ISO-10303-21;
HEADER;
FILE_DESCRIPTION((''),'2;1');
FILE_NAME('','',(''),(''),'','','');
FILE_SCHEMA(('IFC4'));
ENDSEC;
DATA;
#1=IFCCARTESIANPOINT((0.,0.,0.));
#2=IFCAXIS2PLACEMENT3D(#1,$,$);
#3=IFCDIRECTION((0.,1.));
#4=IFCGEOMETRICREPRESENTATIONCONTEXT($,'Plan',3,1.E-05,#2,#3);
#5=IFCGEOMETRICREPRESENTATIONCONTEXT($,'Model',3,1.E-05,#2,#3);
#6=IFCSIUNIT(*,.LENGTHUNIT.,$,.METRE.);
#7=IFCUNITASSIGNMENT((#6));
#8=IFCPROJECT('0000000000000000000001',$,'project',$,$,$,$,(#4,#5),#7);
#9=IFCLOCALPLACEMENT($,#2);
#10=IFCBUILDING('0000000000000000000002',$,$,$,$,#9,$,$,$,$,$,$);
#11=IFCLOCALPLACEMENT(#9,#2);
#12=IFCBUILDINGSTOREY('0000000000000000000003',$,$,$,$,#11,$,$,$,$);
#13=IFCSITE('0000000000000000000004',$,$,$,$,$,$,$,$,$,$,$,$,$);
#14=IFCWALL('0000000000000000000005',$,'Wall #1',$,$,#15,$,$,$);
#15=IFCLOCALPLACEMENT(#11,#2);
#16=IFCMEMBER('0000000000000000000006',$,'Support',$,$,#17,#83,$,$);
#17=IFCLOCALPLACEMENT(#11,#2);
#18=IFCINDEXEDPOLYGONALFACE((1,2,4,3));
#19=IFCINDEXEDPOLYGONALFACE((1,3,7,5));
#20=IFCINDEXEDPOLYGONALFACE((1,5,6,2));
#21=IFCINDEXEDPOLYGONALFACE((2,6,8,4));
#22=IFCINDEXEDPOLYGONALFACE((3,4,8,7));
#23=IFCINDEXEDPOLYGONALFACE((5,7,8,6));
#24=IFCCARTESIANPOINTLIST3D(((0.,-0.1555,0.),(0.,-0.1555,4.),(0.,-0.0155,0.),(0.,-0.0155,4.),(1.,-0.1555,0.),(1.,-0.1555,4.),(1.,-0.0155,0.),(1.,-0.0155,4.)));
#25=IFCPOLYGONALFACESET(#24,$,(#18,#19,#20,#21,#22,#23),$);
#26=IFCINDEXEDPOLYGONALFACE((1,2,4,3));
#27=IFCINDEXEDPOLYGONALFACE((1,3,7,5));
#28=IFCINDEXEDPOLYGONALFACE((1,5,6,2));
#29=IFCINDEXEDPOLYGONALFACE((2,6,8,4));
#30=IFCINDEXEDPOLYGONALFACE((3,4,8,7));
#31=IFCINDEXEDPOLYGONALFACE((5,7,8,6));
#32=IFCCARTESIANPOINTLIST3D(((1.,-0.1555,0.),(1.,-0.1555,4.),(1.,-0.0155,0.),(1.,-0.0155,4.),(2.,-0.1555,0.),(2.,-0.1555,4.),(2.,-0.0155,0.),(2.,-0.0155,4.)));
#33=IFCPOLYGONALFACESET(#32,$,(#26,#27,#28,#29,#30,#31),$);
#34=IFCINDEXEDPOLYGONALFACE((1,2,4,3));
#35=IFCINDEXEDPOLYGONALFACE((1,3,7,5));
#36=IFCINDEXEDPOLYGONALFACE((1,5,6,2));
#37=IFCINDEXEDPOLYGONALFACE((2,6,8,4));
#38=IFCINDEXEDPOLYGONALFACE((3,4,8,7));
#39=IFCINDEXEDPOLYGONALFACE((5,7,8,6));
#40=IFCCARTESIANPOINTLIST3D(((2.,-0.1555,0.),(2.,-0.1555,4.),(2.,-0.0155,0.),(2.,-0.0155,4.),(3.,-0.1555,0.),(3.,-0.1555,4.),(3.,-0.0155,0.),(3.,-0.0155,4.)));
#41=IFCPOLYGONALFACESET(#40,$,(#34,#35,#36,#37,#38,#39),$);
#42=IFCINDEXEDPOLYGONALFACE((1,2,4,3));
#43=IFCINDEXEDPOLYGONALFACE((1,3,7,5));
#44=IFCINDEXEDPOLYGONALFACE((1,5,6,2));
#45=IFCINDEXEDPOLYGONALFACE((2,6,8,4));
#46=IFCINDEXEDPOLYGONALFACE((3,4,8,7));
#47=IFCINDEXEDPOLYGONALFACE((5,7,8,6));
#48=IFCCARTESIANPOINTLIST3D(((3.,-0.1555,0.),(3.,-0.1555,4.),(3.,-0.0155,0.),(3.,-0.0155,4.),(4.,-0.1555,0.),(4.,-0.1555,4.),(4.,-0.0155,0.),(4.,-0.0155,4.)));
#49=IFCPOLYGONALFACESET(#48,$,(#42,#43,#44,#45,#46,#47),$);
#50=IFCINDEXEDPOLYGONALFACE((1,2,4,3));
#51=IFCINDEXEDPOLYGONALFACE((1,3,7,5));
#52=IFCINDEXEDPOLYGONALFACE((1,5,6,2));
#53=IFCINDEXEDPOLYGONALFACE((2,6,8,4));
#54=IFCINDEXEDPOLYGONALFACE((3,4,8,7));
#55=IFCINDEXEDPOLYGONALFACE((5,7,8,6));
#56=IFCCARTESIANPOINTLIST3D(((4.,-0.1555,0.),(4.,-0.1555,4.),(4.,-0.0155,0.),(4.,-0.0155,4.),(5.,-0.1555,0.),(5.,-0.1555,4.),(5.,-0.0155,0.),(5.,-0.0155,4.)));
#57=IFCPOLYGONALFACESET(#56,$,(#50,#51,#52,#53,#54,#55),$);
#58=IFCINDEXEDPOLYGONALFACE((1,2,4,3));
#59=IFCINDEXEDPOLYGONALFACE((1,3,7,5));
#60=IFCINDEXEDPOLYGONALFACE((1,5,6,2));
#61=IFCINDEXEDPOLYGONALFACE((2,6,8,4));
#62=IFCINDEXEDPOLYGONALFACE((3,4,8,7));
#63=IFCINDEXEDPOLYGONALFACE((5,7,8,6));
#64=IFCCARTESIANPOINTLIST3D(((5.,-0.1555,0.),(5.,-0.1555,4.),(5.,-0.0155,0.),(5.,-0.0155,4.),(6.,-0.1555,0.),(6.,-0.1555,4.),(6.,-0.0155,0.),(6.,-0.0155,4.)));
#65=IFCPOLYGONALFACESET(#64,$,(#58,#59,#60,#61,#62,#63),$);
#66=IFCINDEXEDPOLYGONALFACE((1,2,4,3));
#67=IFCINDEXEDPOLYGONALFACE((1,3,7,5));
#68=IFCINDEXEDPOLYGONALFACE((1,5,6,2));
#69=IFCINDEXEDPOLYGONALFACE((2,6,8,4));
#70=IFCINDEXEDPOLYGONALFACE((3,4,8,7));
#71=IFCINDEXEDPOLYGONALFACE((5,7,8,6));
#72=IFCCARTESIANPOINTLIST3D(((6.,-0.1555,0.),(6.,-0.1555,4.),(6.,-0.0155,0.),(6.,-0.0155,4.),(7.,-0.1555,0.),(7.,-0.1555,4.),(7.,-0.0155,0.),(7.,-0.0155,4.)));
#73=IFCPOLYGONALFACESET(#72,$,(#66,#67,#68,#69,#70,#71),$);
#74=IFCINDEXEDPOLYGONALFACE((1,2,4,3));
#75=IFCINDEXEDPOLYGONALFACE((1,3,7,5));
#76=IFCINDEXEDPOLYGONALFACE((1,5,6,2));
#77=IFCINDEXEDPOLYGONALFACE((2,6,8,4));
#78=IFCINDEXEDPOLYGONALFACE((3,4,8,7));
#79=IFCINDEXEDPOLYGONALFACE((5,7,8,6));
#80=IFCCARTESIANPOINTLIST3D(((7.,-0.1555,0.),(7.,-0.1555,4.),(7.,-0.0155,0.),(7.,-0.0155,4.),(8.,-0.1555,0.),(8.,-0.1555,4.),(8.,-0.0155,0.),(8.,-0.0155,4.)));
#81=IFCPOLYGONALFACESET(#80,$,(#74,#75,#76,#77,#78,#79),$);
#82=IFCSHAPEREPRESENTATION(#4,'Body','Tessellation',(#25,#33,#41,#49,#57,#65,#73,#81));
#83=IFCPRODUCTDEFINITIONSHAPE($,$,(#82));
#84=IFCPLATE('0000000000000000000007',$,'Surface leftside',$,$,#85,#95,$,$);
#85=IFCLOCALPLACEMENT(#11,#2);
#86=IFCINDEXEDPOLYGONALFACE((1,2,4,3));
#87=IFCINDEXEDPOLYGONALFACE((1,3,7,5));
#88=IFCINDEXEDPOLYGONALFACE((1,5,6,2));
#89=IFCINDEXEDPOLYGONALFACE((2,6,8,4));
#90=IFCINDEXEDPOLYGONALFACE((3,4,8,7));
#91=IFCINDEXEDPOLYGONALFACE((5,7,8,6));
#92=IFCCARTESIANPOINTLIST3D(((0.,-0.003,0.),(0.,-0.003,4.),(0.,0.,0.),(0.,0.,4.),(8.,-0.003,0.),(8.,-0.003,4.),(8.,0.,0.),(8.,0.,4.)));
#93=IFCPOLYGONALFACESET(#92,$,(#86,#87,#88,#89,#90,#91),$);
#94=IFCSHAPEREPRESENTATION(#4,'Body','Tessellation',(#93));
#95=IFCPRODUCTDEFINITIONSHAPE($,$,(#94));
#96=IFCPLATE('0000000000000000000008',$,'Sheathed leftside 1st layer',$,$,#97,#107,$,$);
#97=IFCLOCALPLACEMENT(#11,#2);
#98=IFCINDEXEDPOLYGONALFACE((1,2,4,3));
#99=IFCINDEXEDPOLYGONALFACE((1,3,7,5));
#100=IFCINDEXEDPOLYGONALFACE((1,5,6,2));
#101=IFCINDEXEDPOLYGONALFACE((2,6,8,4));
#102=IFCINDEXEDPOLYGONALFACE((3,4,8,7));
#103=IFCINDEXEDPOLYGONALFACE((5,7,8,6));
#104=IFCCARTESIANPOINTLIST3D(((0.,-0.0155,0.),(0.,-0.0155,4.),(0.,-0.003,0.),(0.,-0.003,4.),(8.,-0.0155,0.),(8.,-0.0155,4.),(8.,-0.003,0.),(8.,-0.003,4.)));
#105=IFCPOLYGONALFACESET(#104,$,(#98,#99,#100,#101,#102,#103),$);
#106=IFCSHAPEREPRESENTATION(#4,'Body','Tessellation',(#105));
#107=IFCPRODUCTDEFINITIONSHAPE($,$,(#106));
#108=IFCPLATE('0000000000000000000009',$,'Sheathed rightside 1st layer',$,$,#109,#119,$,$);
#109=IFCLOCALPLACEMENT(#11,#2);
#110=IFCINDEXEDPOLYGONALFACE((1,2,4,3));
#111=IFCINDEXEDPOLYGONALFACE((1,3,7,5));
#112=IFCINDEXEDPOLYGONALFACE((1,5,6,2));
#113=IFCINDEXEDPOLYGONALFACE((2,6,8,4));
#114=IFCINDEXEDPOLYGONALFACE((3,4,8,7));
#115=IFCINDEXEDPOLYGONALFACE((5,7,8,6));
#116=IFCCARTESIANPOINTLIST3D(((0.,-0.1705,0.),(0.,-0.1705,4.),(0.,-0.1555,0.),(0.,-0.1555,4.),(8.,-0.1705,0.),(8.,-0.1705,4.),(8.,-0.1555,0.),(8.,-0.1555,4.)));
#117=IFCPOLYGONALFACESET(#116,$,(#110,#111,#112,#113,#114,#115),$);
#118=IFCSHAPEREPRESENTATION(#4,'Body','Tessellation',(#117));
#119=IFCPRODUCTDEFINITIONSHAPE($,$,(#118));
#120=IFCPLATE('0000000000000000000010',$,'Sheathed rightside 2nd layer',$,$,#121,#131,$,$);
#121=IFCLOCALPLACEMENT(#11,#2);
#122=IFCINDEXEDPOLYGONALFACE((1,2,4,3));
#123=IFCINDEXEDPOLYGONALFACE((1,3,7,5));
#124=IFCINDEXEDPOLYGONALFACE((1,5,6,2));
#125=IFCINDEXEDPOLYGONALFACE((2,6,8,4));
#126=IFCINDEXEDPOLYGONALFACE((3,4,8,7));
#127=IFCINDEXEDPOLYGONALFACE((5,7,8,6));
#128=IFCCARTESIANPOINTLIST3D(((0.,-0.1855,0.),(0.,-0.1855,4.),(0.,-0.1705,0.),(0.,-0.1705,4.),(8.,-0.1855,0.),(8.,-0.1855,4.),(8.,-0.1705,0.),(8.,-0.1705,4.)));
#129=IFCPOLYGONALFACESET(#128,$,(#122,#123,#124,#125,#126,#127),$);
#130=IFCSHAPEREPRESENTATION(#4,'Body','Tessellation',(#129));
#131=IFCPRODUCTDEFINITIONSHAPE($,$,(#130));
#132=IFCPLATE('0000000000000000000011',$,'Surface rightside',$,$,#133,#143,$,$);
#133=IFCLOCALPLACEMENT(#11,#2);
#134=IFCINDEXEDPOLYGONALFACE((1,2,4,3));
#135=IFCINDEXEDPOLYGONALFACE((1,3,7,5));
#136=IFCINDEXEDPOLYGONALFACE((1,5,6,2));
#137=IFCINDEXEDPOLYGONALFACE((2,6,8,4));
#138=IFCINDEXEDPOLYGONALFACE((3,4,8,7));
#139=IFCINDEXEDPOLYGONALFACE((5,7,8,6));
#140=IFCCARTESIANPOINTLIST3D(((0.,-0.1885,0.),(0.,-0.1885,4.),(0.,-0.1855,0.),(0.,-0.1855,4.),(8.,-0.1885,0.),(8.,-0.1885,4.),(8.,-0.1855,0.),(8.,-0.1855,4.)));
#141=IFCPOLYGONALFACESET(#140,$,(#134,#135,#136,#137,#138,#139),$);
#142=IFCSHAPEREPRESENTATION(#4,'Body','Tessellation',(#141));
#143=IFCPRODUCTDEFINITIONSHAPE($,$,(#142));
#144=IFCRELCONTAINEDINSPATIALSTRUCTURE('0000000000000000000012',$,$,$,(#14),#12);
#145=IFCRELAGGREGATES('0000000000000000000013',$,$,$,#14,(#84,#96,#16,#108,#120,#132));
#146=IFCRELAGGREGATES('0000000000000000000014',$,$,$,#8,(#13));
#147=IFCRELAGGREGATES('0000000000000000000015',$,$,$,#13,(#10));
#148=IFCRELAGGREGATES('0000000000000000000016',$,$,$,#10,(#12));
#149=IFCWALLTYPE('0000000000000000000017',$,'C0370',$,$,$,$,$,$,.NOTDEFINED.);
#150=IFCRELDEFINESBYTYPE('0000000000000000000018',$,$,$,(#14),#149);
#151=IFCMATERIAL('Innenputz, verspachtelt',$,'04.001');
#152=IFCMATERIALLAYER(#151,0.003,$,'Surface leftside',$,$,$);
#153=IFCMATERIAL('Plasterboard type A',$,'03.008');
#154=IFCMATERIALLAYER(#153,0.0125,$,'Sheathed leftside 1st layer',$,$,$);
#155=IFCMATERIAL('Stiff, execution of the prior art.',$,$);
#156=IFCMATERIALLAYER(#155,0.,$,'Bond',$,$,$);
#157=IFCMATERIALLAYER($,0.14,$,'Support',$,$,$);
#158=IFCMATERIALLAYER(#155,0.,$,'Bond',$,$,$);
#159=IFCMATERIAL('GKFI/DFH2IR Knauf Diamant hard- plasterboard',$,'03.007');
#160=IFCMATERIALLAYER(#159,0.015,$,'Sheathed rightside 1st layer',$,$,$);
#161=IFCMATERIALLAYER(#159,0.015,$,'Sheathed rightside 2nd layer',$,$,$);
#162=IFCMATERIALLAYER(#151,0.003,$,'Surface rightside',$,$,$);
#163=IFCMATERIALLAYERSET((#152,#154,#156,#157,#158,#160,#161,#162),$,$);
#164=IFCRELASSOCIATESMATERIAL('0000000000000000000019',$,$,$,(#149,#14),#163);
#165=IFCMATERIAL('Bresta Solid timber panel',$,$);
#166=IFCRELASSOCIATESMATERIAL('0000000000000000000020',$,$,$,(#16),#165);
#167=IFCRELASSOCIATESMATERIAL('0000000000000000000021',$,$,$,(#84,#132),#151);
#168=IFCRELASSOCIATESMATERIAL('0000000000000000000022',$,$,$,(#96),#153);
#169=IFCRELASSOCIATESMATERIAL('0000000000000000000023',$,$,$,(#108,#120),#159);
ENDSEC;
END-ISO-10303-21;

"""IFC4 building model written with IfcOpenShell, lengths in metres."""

from ifc_helpers import new_model, si_unit, direction, frame, frame_2d, origin, origin_with_axes, place, context, project, spatial, rectangle, extrude, material, layer, layer_set, type_object, element, aggregate, save


model = new_model("IFC4")

# Units and contexts
plan_context = context("Plan", 3, precision=1e-05, world=origin(), true_north=direction((0.0, 1.0)))
model_context = context("Model", 3, precision=1e-05, world=origin(), true_north=direction((0.0, 1.0)))
ifc_project = project(units=[si_unit("LENGTHUNIT", "METRE")], contexts=[plan_context, model_context])

# Site, building, storey
site = spatial("IfcSite", under=ifc_project)
building_placement = place(None, origin())
building = spatial("IfcBuilding", under=site, at=building_placement)
storey_placement = place(building_placement, origin())
storey = spatial("IfcBuildingStorey", under=building, at=storey_placement)

# Wall, member, plates
ifc_material_1 = material(Name="Innenputz, verspachtelt", Category="04.001")
ifc_layer_1 = layer(ifc_material_1, 0.003, Name="Surface leftside")
ifc_material_2 = material(Name="Plasterboard type A", Category="03.008")
ifc_layer_2 = layer(ifc_material_2, 0.0125, Name="Sheathed leftside 1st layer")
ifc_material_3 = material(Name="Stiff, execution of the prior art.")
ifc_layer_3 = layer(ifc_material_3, 0.0, Name="Bond")
ifc_layer_4 = layer(None, 0.14, Name="Support")
ifc_layer_5 = layer(ifc_material_3, 0.0, Name="Bond")
ifc_material_4 = material(Name="GKFI/DFH2IR Knauf Diamant hard- plasterboard", Category="03.007")
ifc_layer_6 = layer(ifc_material_4, 0.015, Name="Sheathed rightside 1st layer")
ifc_layer_7 = layer(ifc_material_4, 0.015, Name="Sheathed rightside 2nd layer")
ifc_layer_8 = layer(ifc_material_1, 0.003, Name="Surface rightside")
ifc_layer_set = layer_set([ifc_layer_1, ifc_layer_2, ifc_layer_3, ifc_layer_4, ifc_layer_5, ifc_layer_6, ifc_layer_7, ifc_layer_8])
wall_type = type_object("IfcWallType", Name="C0370", PredefinedType="NOTDEFINED", material=ifc_layer_set)
wall_placement = place(None, frame((0.0, 0.0, 0.0), z_axis=(0.0, -1.0, 0.0), x_axis=(1.0, 0.0, 0.0)))
wall = element("IfcWall", 1, at=wall_placement, inside=storey, type_object=wall_type, material=ifc_layer_set, Name="Wall #1")
ifc_material_5 = material(Name="Bresta Solid timber panel")
member_placement = place(wall_placement, origin())
member = element("IfcMember", 2, at=member_placement, material=ifc_material_5, Name="Support", context=plan_context, shape_type="SweptSolid", body=[
    extrude(rectangle(XDim=1.0, YDim=0.14, at=frame_2d((0.5, 0.07), x_axis=(1.0, 0.0))), frame((0.0, 4.0, 0.0155), z_axis=(0.0, -1.0, 0.0), x_axis=(1.0, 0.0, 0.0)), (0.0, 0.0, 1.0), 4.0),
    extrude(rectangle(XDim=1.0, YDim=0.14, at=frame_2d((0.5, 0.07), x_axis=(1.0, 0.0))), frame((1.0, 4.0, 0.0155), z_axis=(0.0, -1.0, 0.0), x_axis=(1.0, 0.0, 0.0)), (0.0, 0.0, 1.0), 4.0),
    extrude(rectangle(XDim=1.0, YDim=0.14, at=frame_2d((0.5, 0.07), x_axis=(1.0, 0.0))), frame((2.0, 4.0, 0.0155), z_axis=(0.0, -1.0, 0.0), x_axis=(1.0, 0.0, 0.0)), (0.0, 0.0, 1.0), 4.0),
    extrude(rectangle(XDim=1.0, YDim=0.14, at=frame_2d((0.5, 0.07), x_axis=(1.0, 0.0))), frame((3.0, 4.0, 0.0155), z_axis=(0.0, -1.0, 0.0), x_axis=(1.0, 0.0, 0.0)), (0.0, 0.0, 1.0), 4.0),
    extrude(rectangle(XDim=1.0, YDim=0.14, at=frame_2d((0.5, 0.07), x_axis=(1.0, 0.0))), frame((4.0, 4.0, 0.0155), z_axis=(0.0, -1.0, 0.0), x_axis=(1.0, 0.0, 0.0)), (0.0, 0.0, 1.0), 4.0),
    extrude(rectangle(XDim=1.0, YDim=0.14, at=frame_2d((0.5, 0.07), x_axis=(1.0, 0.0))), frame((5.0, 4.0, 0.0155), z_axis=(0.0, -1.0, 0.0), x_axis=(1.0, 0.0, 0.0)), (0.0, 0.0, 1.0), 4.0),
    extrude(rectangle(XDim=1.0, YDim=0.14, at=frame_2d((0.5, 0.07), x_axis=(1.0, 0.0))), frame((6.0, 4.0, 0.0155), z_axis=(0.0, -1.0, 0.0), x_axis=(1.0, 0.0, 0.0)), (0.0, 0.0, 1.0), 4.0),
    extrude(rectangle(XDim=1.0, YDim=0.14, at=frame_2d((0.5, 0.07), x_axis=(1.0, 0.0))), frame((7.0, 4.0, 0.0155), z_axis=(0.0, -1.0, 0.0), x_axis=(1.0, 0.0, 0.0)), (0.0, 0.0, 1.0), 4.0),
])
plate_1_placement = place(wall_placement, origin())
plate_1 = element("IfcPlate", 3, at=plate_1_placement, material=ifc_material_1, Name="Surface leftside", context=plan_context, shape_type="SweptSolid", body=[
    extrude(rectangle(XDim=8.0, YDim=4.0, at=frame_2d((4.0, 2.0), x_axis=(1.0, 0.0))), origin_with_axes(), (0.0, 0.0, 1.0), 0.003),
])
plate_2_placement = place(wall_placement, origin())
plate_2 = element("IfcPlate", 4, at=plate_2_placement, material=ifc_material_2, Name="Sheathed leftside 1st layer", context=plan_context, shape_type="SweptSolid", body=[
    extrude(rectangle(XDim=8.0, YDim=4.0, at=frame_2d((4.0, 2.0), x_axis=(1.0, 0.0))), frame((0.0, 0.0, 0.003), z_axis=(0.0, 0.0, 1.0), x_axis=(1.0, 0.0, 0.0)), (0.0, 0.0, 1.0), 0.0125),
])
plate_3_placement = place(wall_placement, origin())
plate_3 = element("IfcPlate", 5, at=plate_3_placement, material=ifc_material_4, Name="Sheathed rightside 1st layer", context=plan_context, shape_type="SweptSolid", body=[
    extrude(rectangle(XDim=8.0, YDim=4.0, at=frame_2d((4.0, 2.0), x_axis=(1.0, 0.0))), frame((0.0, 0.0, 0.1555), z_axis=(0.0, 0.0, 1.0), x_axis=(1.0, 0.0, 0.0)), (0.0, 0.0, 1.0), 0.015),
])
plate_4_placement = place(wall_placement, origin())
plate_4 = element("IfcPlate", 6, at=plate_4_placement, material=ifc_material_4, Name="Sheathed rightside 2nd layer", context=plan_context, shape_type="SweptSolid", body=[
    extrude(rectangle(XDim=8.0, YDim=4.0, at=frame_2d((4.0, 2.0), x_axis=(1.0, 0.0))), frame((0.0, 0.0, 0.1705), z_axis=(0.0, 0.0, 1.0), x_axis=(1.0, 0.0, 0.0)), (0.0, 0.0, 1.0), 0.015),
])
plate_5_placement = place(wall_placement, origin())
plate_5 = element("IfcPlate", 7, at=plate_5_placement, material=ifc_material_1, Name="Surface rightside", context=plan_context, shape_type="SweptSolid", body=[
    extrude(rectangle(XDim=8.0, YDim=4.0, at=frame_2d((4.0, 2.0), x_axis=(1.0, 0.0))), frame((0.0, 0.0, 0.1855), z_axis=(0.0, 0.0, 1.0), x_axis=(1.0, 0.0, 0.0)), (0.0, 0.0, 1.0), 0.003),
])
aggregate(wall, [plate_1, plate_2, member, plate_3, plate_4, plate_5])

save(model, "model.ifc")
